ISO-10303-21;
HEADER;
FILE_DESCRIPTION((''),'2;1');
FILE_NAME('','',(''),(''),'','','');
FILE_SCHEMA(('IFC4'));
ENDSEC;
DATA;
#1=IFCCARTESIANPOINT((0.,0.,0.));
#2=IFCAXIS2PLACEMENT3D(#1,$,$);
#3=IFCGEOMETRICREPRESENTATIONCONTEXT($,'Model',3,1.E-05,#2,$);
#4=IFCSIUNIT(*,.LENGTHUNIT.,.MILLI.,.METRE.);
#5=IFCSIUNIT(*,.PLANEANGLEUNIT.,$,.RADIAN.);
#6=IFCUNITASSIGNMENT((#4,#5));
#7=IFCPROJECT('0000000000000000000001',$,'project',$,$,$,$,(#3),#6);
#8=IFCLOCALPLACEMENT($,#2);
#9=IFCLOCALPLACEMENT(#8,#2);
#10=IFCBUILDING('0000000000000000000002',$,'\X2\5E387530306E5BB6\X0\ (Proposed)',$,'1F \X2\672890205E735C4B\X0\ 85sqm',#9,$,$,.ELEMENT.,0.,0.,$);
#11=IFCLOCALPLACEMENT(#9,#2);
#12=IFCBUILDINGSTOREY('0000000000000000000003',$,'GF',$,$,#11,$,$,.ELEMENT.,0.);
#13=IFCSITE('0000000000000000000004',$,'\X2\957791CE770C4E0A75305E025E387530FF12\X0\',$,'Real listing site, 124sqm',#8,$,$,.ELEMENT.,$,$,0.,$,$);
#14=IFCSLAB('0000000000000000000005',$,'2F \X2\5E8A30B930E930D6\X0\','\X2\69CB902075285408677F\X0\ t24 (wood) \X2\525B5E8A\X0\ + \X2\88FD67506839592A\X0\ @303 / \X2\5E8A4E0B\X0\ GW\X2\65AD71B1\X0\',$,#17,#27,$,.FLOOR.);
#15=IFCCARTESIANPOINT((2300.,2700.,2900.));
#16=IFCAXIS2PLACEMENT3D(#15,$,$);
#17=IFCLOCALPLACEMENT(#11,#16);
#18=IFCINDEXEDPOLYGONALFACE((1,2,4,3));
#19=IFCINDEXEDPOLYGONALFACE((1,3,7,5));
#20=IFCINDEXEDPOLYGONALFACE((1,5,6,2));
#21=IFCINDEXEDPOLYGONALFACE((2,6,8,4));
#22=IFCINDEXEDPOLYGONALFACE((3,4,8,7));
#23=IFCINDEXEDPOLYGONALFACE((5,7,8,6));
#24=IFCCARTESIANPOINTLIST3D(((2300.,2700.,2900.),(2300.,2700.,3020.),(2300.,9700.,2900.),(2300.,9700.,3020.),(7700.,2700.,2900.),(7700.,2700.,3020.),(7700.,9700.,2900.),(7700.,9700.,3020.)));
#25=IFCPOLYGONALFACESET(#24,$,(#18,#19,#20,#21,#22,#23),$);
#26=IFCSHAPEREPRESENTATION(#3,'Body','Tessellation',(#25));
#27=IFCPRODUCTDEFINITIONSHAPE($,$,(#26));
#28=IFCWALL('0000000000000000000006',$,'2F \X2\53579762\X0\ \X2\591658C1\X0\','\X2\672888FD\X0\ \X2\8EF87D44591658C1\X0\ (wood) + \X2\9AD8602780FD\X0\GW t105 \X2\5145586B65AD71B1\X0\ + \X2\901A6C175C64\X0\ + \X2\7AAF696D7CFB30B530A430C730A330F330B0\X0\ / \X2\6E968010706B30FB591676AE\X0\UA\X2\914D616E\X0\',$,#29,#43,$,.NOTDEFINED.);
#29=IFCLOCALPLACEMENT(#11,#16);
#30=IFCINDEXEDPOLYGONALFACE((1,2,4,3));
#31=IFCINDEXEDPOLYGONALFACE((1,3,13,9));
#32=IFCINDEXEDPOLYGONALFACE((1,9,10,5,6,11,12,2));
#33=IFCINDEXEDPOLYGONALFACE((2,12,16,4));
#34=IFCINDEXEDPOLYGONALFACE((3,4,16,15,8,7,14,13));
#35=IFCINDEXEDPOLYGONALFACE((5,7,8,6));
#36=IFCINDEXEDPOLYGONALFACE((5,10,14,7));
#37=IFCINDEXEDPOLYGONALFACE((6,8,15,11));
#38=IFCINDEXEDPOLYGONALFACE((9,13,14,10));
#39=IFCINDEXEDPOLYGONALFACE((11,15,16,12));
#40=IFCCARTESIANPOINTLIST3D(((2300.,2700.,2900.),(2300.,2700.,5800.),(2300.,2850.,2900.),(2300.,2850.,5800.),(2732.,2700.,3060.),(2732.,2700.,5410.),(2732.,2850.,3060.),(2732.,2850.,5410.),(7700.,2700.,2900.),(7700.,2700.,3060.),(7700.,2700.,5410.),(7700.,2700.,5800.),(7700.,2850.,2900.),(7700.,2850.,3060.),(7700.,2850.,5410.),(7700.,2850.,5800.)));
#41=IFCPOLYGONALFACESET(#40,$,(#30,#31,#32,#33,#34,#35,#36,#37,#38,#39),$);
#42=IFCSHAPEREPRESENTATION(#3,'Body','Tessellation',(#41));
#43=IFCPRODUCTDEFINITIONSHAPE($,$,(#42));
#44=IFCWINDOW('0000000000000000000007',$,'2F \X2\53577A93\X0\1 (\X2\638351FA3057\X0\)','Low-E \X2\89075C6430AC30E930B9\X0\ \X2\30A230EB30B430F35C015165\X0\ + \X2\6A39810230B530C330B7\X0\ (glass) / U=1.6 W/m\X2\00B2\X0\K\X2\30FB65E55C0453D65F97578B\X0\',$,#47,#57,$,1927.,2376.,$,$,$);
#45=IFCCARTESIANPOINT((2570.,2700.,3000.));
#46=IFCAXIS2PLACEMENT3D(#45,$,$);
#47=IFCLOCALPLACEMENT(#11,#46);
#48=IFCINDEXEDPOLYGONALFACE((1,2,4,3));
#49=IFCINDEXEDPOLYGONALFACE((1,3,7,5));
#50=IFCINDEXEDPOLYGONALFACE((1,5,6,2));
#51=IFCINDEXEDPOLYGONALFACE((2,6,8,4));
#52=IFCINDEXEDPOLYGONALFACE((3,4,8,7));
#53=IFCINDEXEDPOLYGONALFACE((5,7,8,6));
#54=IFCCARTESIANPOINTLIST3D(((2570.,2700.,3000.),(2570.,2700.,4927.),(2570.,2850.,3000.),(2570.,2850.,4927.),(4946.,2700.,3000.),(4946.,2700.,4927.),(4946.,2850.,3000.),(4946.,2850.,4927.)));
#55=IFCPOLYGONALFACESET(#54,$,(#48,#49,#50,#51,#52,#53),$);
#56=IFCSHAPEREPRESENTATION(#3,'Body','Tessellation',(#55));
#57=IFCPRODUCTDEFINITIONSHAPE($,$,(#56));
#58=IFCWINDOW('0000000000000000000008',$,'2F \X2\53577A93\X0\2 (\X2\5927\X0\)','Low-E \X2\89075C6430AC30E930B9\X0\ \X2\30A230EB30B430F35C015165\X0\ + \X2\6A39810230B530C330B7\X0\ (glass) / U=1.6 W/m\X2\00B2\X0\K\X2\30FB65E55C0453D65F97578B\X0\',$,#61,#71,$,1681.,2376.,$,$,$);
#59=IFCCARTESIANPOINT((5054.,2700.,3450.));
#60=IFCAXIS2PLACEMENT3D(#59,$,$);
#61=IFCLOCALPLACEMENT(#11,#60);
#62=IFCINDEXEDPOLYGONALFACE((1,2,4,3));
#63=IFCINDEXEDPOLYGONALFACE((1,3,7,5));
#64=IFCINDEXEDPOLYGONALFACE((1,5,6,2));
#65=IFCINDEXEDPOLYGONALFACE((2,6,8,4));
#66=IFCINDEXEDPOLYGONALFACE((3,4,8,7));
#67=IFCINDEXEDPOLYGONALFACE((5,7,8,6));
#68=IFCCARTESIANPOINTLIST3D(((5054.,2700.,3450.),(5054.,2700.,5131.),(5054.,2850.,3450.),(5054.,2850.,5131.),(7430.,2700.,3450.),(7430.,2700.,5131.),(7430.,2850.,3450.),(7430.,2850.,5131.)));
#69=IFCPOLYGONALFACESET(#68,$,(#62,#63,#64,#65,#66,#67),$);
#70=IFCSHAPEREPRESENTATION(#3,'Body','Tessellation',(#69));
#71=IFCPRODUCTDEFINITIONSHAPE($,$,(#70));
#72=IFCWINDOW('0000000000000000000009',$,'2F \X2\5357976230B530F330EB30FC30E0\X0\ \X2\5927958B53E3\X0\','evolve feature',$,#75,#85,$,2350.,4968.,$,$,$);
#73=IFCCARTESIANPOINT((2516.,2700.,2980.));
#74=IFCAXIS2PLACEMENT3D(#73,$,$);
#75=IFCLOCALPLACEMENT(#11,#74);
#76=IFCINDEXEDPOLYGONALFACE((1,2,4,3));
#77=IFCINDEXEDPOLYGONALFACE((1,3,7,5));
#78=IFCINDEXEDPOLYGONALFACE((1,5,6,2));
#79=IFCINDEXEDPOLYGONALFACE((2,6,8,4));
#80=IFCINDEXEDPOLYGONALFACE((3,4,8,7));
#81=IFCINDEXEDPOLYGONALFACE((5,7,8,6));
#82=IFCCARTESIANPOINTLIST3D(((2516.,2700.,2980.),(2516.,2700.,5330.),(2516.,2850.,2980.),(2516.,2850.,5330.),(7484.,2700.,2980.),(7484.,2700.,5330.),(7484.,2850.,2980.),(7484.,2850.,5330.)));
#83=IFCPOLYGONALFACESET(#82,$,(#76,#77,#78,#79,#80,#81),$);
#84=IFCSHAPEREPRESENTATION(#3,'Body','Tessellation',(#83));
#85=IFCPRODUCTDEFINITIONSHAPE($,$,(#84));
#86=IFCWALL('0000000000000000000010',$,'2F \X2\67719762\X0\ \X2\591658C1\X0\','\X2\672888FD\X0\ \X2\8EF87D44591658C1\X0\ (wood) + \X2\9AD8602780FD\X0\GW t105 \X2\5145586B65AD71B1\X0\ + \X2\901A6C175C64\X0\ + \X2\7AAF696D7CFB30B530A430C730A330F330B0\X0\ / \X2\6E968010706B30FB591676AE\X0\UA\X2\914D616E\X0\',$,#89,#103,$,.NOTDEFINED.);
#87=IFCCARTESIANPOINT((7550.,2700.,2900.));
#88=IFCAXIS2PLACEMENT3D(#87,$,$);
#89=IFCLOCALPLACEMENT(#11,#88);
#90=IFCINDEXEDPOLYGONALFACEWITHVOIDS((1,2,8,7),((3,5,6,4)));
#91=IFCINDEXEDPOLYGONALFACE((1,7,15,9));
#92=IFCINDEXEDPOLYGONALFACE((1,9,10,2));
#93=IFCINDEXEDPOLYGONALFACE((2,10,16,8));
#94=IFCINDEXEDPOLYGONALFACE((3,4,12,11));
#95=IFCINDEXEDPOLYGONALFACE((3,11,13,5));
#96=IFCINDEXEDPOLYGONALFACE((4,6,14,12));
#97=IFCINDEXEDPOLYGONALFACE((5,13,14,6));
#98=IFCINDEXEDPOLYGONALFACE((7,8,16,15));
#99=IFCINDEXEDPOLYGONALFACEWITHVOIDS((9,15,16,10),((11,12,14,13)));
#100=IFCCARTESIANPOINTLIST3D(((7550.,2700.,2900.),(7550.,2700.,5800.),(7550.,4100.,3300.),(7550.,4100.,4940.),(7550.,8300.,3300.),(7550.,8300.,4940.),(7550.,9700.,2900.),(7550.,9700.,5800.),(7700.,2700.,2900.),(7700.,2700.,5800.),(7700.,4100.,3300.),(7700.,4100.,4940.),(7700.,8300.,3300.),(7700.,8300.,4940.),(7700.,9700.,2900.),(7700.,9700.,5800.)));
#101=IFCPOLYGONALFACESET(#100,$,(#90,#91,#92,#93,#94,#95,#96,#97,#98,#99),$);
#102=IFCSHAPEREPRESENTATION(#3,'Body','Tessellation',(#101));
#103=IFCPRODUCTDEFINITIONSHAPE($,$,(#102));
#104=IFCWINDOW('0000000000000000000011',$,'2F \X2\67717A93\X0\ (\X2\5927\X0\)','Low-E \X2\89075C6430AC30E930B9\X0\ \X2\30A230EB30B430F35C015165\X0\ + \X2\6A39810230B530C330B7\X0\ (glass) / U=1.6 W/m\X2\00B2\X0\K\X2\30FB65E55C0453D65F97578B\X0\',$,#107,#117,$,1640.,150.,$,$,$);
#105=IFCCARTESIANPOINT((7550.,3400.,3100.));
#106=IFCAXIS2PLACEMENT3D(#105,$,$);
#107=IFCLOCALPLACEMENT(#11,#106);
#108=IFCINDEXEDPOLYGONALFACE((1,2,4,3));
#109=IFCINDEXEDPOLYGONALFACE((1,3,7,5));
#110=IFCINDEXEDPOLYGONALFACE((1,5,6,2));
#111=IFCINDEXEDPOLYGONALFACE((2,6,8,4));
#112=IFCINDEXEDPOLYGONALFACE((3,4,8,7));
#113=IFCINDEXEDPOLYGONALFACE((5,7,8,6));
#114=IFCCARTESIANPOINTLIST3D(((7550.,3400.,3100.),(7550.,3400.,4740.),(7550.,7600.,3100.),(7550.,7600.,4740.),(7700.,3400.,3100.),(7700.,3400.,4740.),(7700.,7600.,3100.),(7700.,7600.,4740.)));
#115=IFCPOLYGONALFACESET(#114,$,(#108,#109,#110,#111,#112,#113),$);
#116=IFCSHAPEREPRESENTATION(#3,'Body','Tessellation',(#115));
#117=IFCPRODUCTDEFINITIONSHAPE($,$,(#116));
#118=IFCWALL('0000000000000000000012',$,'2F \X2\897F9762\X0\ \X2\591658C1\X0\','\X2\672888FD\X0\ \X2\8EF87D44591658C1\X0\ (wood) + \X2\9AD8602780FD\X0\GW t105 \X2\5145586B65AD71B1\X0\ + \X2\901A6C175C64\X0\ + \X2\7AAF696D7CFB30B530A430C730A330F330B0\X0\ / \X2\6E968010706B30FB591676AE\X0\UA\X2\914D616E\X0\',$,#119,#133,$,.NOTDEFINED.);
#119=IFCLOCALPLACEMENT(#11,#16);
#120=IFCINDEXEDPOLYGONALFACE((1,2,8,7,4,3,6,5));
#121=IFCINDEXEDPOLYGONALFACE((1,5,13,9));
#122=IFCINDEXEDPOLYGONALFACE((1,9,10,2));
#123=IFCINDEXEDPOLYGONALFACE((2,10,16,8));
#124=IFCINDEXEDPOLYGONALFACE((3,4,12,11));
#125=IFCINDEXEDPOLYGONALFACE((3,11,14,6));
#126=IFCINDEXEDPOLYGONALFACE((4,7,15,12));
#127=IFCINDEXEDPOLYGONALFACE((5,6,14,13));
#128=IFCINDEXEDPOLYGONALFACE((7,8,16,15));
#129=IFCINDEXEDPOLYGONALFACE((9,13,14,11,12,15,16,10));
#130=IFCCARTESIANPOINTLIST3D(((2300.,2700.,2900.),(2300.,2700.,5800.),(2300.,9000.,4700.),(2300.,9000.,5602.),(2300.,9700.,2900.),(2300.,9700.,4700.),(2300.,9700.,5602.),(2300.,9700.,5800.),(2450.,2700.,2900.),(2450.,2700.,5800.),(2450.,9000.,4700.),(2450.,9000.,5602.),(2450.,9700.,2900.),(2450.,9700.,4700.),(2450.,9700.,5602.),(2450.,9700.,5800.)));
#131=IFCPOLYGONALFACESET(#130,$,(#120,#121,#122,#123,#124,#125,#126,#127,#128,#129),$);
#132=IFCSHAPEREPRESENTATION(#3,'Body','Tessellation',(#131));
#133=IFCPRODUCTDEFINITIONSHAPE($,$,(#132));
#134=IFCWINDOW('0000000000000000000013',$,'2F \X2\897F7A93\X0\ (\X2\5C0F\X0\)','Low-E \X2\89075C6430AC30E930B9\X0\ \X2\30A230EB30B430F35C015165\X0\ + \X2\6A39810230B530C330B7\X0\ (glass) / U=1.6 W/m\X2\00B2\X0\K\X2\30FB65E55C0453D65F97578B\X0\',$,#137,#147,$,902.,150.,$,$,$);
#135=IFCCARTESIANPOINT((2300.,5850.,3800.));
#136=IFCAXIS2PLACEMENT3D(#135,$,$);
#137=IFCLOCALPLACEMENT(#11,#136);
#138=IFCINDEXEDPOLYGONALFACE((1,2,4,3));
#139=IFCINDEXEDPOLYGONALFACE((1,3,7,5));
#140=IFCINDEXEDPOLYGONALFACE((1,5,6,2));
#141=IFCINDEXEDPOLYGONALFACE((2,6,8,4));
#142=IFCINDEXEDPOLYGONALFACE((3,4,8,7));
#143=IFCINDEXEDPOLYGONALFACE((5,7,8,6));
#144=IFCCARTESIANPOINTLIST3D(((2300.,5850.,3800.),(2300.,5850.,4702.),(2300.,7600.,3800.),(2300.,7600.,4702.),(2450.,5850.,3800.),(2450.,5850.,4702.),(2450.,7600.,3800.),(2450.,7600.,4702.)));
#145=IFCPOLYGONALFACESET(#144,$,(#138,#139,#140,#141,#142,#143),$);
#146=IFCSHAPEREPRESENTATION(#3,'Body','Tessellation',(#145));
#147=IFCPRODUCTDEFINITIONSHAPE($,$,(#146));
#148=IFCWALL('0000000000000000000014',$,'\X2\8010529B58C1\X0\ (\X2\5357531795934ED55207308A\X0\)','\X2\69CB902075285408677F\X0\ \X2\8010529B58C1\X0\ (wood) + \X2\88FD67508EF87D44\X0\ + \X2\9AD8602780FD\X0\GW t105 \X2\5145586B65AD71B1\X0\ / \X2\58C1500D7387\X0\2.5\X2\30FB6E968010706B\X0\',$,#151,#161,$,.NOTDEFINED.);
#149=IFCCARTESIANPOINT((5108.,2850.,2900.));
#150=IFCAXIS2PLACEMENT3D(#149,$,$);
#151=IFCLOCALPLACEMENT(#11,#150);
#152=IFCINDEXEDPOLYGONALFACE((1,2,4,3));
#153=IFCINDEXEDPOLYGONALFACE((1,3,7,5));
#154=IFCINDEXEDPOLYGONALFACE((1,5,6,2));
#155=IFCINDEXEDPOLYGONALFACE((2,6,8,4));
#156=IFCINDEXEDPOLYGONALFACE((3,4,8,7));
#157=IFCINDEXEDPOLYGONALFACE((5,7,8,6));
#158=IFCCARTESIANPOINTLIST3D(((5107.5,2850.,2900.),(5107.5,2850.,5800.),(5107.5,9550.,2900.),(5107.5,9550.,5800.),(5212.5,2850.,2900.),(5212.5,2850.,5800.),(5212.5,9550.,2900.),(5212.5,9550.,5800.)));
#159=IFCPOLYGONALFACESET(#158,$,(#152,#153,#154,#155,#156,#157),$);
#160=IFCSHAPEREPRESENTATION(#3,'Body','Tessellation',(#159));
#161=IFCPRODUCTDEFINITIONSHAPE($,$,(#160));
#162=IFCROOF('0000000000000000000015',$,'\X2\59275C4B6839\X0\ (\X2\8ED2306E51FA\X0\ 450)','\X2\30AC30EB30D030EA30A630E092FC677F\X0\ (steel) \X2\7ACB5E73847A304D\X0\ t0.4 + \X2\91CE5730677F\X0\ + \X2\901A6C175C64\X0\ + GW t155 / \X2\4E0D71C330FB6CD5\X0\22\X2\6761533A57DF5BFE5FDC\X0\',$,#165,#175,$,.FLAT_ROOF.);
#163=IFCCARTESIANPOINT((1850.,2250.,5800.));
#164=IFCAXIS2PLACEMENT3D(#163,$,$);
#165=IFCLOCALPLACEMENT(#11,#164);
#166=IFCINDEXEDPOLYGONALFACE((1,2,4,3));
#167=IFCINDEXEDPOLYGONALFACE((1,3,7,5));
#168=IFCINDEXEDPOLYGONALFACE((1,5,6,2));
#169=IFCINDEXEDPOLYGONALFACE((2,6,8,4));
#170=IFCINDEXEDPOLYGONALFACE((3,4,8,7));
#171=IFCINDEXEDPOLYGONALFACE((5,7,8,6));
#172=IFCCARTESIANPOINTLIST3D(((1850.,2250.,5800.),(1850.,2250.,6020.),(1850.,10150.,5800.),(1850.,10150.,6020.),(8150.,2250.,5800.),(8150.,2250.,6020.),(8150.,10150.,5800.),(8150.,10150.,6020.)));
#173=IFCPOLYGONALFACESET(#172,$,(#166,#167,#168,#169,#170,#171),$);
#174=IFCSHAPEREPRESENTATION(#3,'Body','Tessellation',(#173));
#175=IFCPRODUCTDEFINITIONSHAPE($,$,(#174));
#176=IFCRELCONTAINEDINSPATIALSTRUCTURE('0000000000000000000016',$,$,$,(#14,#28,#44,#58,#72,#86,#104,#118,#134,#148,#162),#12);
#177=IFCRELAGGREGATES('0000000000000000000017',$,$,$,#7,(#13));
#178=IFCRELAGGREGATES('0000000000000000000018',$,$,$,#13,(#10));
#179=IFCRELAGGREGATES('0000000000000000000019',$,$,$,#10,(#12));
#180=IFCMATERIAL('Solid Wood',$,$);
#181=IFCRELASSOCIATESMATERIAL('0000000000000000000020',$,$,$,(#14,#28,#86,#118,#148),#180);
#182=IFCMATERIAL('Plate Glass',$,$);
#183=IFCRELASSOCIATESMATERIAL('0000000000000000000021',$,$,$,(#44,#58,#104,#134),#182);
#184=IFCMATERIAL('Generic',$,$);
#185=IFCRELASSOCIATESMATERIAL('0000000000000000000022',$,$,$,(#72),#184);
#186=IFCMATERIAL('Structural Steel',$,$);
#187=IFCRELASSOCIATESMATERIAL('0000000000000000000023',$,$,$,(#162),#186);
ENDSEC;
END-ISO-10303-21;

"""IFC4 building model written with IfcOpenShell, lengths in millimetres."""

from ifc_helpers import new_model, si_unit, frame, frame_2d, origin, place, context, project, spatial, rectangle, extrude, material, element, fill, save


model = new_model("IFC4")

# Units and contexts
model_context = context("Model", 3, precision=1e-05, world=origin())
ifc_project = project(units=[si_unit("LENGTHUNIT", "METRE", prefix="MILLI"), si_unit("PLANEANGLEUNIT", "RADIAN")], contexts=[model_context])

# Site, building, storey
site_placement = place(None, origin())
site = spatial("IfcSite", under=ifc_project, at=site_placement, Name="長野県上田市常田２", ObjectType="Real listing site, 124sqm", CompositionType="ELEMENT", RefElevation=0.0)
building_placement = place(site_placement, origin())
building = spatial("IfcBuilding", under=site, at=building_placement, Name="常田の家 (Proposed)", ObjectType="1F 木造平屋 85sqm", CompositionType="ELEMENT", ElevationOfRefHeight=0.0, ElevationOfTerrain=0.0)
storey_placement = place(building_placement, origin())
storey = spatial("IfcBuildingStorey", under=building, at=storey_placement, Name="GF", CompositionType="ELEMENT", Elevation=0.0)

# Slab
ifc_material_1 = material(Name="Solid Wood")
slab_placement = place(storey_placement, frame((2300.0, 2700.0, 2900.0)))
element("IfcSlab", 1, at=slab_placement, inside=storey, material=ifc_material_1, Name="2F 床スラブ", Description="構造用合板 t24 (wood) 剛床 + 製材根太 @303 / 床下 GW断熱", PredefinedType="FLOOR", context=model_context, shape_type="SweptSolid", body=[
    extrude(rectangle(XDim=5400.0, YDim=7000.0, at=frame_2d((2700.0, 3500.0))), frame((2300.0, 2700.0, 2900.0)), (0.0, 0.0, 1.0), 120.0),
])

# Wall, openings, windows
wall_1_placement = place(storey_placement, frame((2300.0, 2700.0, 2900.0)))
wall_1 = element("IfcWall", 2, at=wall_1_placement, inside=storey, material=ifc_material_1, Name="2F 南面 外壁", Description="木製 軸組外壁 (wood) + 高性能GW t105 充填断熱 + 通気層 + 窯業系サイディング / 準耐火・外皮UA配慮", PredefinedType="NOTDEFINED", context=model_context, shape_type="SweptSolid", body=[
    extrude(rectangle(XDim=5400.0, YDim=150.0, at=frame_2d((2700.0, 75.0))), frame((2300.0, 2700.0, 2900.0)), (0.0, 0.0, 1.0), 2900.0),
])
opening_1_placement = place(storey_placement, frame((2570.0, 2700.0, 3000.0)))
opening_1 = element("IfcOpeningElement", 3, at=opening_1_placement, cuts=wall_1, PredefinedType="NOTDEFINED", context=model_context, shape_type="SweptSolid", body=[
    extrude(rectangle(XDim=2376.0, YDim=150.0, at=frame_2d((1188.0, 75.0))), frame((2570.0, 2700.0, 3000.0)), (0.0, 0.0, 1.0), 1927.0),
])
opening_2_placement = place(storey_placement, frame((5054.0, 2700.0, 3450.0)))
opening_2 = element("IfcOpeningElement", 4, at=opening_2_placement, cuts=wall_1, PredefinedType="NOTDEFINED", context=model_context, shape_type="SweptSolid", body=[
    extrude(rectangle(XDim=2376.0, YDim=150.0, at=frame_2d((1188.0, 75.0))), frame((5054.0, 2700.0, 3450.0)), (0.0, 0.0, 1.0), 1681.0),
])
opening_3_placement = place(storey_placement, frame((2516.0, 2700.0, 2980.0)))
opening_3 = element("IfcOpeningElement", 5, at=opening_3_placement, cuts=wall_1, PredefinedType="NOTDEFINED", context=model_context, shape_type="SweptSolid", body=[
    extrude(rectangle(XDim=4968.0, YDim=150.0, at=frame_2d((2484.0, 75.0))), frame((2516.0, 2700.0, 2980.0)), (0.0, 0.0, 1.0), 2350.0),
])
ifc_material_2 = material(Name="Plate Glass")
window_1_placement = place(storey_placement, frame((2570.0, 2700.0, 3000.0)))
window_1 = element("IfcWindow", 6, at=window_1_placement, inside=storey, material=ifc_material_2, Name="2F 南窓1 (掃出し)", Description="Low-E 複層ガラス アルゴン封入 + 樹脂サッシ (glass) / U=1.6 W/m²K・日射取得型", OverallHeight=1927.0, OverallWidth=2376.0, context=model_context, shape_type="SweptSolid", body=[
    extrude(rectangle(XDim=2376.0, YDim=150.0, at=frame_2d((1188.0, 75.0))), frame((2570.0, 2700.0, 3000.0)), (0.0, 0.0, 1.0), 1927.0),
])
fill(opening_1, window_1)
window_2_placement = place(storey_placement, frame((5054.0, 2700.0, 3450.0)))
window_2 = element("IfcWindow", 7, at=window_2_placement, inside=storey, material=ifc_material_2, Name="2F 南窓2 (大)", Description="Low-E 複層ガラス アルゴン封入 + 樹脂サッシ (glass) / U=1.6 W/m²K・日射取得型", OverallHeight=1681.0, OverallWidth=2376.0, context=model_context, shape_type="SweptSolid", body=[
    extrude(rectangle(XDim=2376.0, YDim=150.0, at=frame_2d((1188.0, 75.0))), frame((5054.0, 2700.0, 3450.0)), (0.0, 0.0, 1.0), 1681.0),
])
fill(opening_2, window_2)
ifc_material_3 = material(Name="Generic")
window_3_placement = place(storey_placement, frame((2516.0, 2700.0, 2980.0)))
window_3 = element("IfcWindow", 8, at=window_3_placement, inside=storey, material=ifc_material_3, Name="2F 南面サンルーム 大開口", Description="evolve feature", OverallHeight=2350.0, OverallWidth=4968.0, context=model_context, shape_type="SweptSolid", body=[
    extrude(rectangle(XDim=4968.0, YDim=150.0, at=frame_2d((2484.0, 75.0))), frame((2516.0, 2700.0, 2980.0)), (0.0, 0.0, 1.0), 2350.0),
])
fill(opening_3, window_3)

# Walls, openings, windows
wall_2_placement = place(storey_placement, frame((7550.0, 2700.0, 2900.0)))
wall_2 = element("IfcWall", 9, at=wall_2_placement, inside=storey, material=ifc_material_1, Name="2F 東面 外壁", Description="木製 軸組外壁 (wood) + 高性能GW t105 充填断熱 + 通気層 + 窯業系サイディング / 準耐火・外皮UA配慮", PredefinedType="NOTDEFINED", context=model_context, shape_type="SweptSolid", body=[
    extrude(rectangle(XDim=150.0, YDim=7000.0, at=frame_2d((75.0, 3500.0))), frame((7550.0, 2700.0, 2900.0)), (0.0, 0.0, 1.0), 2900.0),
])
opening_4_placement = place(storey_placement, frame((7550.0, 3400.0, 3100.0)))
opening_4 = element("IfcOpeningElement", 10, at=opening_4_placement, cuts=wall_2, PredefinedType="NOTDEFINED", context=model_context, shape_type="SweptSolid", body=[
    extrude(rectangle(XDim=150.0, YDim=4200.0, at=frame_2d((75.0, 2100.0))), frame((7550.0, 3400.0, 3100.0)), (0.0, 0.0, 1.0), 1640.0),
])
window_4_placement = place(storey_placement, frame((7550.0, 3400.0, 3100.0)))
window_4 = element("IfcWindow", 11, at=window_4_placement, inside=storey, material=ifc_material_2, Name="2F 東窓 (大)", Description="Low-E 複層ガラス アルゴン封入 + 樹脂サッシ (glass) / U=1.6 W/m²K・日射取得型", OverallHeight=1640.0, OverallWidth=150.0, context=model_context, shape_type="SweptSolid", body=[
    extrude(rectangle(XDim=150.0, YDim=4200.0, at=frame_2d((75.0, 2100.0))), frame((7550.0, 3400.0, 3100.0)), (0.0, 0.0, 1.0), 1640.0),
])
fill(opening_4, window_4)
wall_3_placement = place(storey_placement, frame((2300.0, 2700.0, 2900.0)))
wall_3 = element("IfcWall", 12, at=wall_3_placement, inside=storey, material=ifc_material_1, Name="2F 西面 外壁", Description="木製 軸組外壁 (wood) + 高性能GW t105 充填断熱 + 通気層 + 窯業系サイディング / 準耐火・外皮UA配慮", PredefinedType="NOTDEFINED", context=model_context, shape_type="SweptSolid", body=[
    extrude(rectangle(XDim=150.0, YDim=7000.0, at=frame_2d((75.0, 3500.0))), frame((2300.0, 2700.0, 2900.0)), (0.0, 0.0, 1.0), 2900.0),
])
opening_5_placement = place(storey_placement, frame((2300.0, 5850.0, 3800.0)))
opening_5 = element("IfcOpeningElement", 13, at=opening_5_placement, cuts=wall_3, PredefinedType="NOTDEFINED", context=model_context, shape_type="SweptSolid", body=[
    extrude(rectangle(XDim=150.0, YDim=1750.0, at=frame_2d((75.0, 875.0))), frame((2300.0, 5850.0, 3800.0)), (0.0, 0.0, 1.0), 902.0),
])
window_5_placement = place(storey_placement, frame((2300.0, 5850.0, 3800.0)))
window_5 = element("IfcWindow", 14, at=window_5_placement, inside=storey, material=ifc_material_2, Name="2F 西窓 (小)", Description="Low-E 複層ガラス アルゴン封入 + 樹脂サッシ (glass) / U=1.6 W/m²K・日射取得型", OverallHeight=902.0, OverallWidth=150.0, context=model_context, shape_type="SweptSolid", body=[
    extrude(rectangle(XDim=150.0, YDim=1750.0, at=frame_2d((75.0, 875.0))), frame((2300.0, 5850.0, 3800.0)), (0.0, 0.0, 1.0), 902.0),
])
fill(opening_5, window_5)

# Wall
wall_4_placement = place(storey_placement, frame((5108.0, 2850.0, 2900.0)))
element("IfcWall", 15, at=wall_4_placement, inside=storey, material=ifc_material_1, Name="耐力壁 (南北間仕切り)", Description="構造用合板 耐力壁 (wood) + 製材軸組 + 高性能GW t105 充填断熱 / 壁倍率2.5・準耐火", PredefinedType="NOTDEFINED", context=model_context, shape_type="SweptSolid", body=[
    extrude(rectangle(XDim=105.0, YDim=6700.0, at=frame_2d((52.0, 3350.0))), frame((5108.0, 2850.0, 2900.0)), (0.0, 0.0, 1.0), 2900.0),
])

# Roof
ifc_material_4 = material(Name="Structural Steel")
roof_placement = place(storey_placement, frame((1850.0, 2250.0, 5800.0)))
element("IfcRoof", 16, at=roof_placement, inside=storey, material=ifc_material_4, Name="大屋根 (軒の出 450)", Description="ガルバリウム鋼板 (steel) 立平葺き t0.4 + 野地板 + 通気層 + GW t155 / 不燃・法22条区域対応", PredefinedType="FLAT_ROOF", context=model_context, shape_type="SweptSolid", body=[
    extrude(rectangle(XDim=6300.0, YDim=7900.0, at=frame_2d((3150.0, 3950.0))), frame((1850.0, 2250.0, 5800.0)), (0.0, 0.0, 1.0), 220.0),
])

save(model, "model.ifc")
